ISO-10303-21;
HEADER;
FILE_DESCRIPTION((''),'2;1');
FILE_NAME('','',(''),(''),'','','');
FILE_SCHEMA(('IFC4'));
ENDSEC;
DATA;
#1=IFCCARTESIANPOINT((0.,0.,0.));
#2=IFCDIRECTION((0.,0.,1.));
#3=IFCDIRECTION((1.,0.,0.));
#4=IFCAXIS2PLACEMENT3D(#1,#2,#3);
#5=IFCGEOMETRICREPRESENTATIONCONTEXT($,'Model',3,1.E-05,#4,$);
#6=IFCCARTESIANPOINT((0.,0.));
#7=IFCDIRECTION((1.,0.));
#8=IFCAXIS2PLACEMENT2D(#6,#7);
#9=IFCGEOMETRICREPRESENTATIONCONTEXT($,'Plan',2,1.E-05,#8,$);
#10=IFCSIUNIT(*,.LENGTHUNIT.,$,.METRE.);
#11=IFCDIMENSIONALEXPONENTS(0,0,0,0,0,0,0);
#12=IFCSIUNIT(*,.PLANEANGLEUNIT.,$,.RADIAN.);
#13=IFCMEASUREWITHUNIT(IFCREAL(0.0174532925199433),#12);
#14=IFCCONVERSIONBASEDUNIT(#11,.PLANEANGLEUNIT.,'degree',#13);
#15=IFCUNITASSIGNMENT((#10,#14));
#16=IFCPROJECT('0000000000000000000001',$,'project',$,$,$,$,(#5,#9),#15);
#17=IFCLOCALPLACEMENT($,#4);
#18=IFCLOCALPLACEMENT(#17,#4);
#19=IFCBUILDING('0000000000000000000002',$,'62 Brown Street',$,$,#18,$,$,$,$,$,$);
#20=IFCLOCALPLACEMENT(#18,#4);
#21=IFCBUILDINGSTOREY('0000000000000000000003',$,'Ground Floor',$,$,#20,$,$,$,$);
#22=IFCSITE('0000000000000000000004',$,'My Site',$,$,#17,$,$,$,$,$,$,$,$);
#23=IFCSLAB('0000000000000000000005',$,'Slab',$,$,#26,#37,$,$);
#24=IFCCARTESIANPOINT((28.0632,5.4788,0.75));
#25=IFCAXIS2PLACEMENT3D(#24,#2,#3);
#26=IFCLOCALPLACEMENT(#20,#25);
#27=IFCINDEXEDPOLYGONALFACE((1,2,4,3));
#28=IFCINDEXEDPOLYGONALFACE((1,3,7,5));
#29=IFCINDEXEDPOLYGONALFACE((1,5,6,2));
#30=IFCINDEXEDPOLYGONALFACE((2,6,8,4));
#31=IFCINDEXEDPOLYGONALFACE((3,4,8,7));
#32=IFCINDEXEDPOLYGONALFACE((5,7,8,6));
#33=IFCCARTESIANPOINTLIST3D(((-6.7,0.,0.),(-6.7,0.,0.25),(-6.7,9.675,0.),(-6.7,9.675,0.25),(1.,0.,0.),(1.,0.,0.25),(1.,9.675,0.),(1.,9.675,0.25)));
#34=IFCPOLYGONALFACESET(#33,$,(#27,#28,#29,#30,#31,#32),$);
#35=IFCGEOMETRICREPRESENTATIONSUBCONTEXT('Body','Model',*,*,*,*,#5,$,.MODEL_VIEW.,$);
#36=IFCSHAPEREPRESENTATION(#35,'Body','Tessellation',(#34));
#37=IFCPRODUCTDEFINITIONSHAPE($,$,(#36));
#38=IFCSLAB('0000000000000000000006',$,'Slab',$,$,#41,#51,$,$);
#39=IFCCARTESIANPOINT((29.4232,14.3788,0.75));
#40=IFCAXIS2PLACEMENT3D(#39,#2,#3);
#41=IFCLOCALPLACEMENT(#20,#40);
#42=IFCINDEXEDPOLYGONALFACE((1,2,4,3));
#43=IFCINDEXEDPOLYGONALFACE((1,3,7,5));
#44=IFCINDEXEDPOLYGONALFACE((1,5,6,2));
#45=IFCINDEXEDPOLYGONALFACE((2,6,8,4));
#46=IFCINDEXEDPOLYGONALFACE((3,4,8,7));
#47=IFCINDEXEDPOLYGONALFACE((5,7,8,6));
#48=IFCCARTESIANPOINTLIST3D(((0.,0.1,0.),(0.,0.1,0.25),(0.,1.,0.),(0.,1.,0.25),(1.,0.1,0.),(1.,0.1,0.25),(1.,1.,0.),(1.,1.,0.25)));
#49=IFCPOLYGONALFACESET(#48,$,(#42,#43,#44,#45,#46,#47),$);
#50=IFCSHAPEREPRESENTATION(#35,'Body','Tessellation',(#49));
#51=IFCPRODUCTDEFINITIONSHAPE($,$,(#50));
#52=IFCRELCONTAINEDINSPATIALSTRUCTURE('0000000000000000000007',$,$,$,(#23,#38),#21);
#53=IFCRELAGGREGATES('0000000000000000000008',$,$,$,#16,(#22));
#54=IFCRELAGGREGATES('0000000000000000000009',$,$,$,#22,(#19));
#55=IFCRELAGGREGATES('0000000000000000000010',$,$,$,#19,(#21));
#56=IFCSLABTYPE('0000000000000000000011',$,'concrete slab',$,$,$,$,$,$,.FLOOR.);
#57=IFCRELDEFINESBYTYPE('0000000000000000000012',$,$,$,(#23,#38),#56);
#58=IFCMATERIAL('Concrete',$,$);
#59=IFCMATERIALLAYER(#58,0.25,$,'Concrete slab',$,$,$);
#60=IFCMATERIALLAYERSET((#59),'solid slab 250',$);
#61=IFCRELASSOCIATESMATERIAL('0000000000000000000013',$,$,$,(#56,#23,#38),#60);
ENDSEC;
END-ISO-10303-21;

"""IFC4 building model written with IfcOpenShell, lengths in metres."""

from ifc_helpers import new_model, entity, si_unit, converted_unit, frame, origin_with_axes, origin_2d_with_axis, place, context, subcontext, project, spatial, line, indexed_curve, outline, extrude, material, layer, layer_set, layer_usage, type_object, element, save


model = new_model("IFC4")

# Units and contexts
model_context = context("Model", 3, precision=1e-05, world=origin_with_axes())
plan_context = context("Plan", 2, precision=1e-05, world=origin_2d_with_axis())
body_context_1 = subcontext(model_context, "Body", "Model", "MODEL_VIEW")
ifc_project = project(units=[si_unit("LENGTHUNIT", "METRE"), converted_unit("PLANEANGLEUNIT", "degree", entity("IfcReal", 0.0174532925199433), si_unit("PLANEANGLEUNIT", "RADIAN"), dimensions=[0, 0, 0, 0, 0, 0, 0])], contexts=[model_context, plan_context])

# Site, building, storey
site_placement = place(None, origin_with_axes())
site = spatial("IfcSite", under=ifc_project, at=site_placement, Name="My Site")
building_placement = place(site_placement, origin_with_axes())
building = spatial("IfcBuilding", under=site, at=building_placement, Name="62 Brown Street")
storey_placement = place(building_placement, origin_with_axes())
storey = spatial("IfcBuildingStorey", under=building, at=storey_placement, Name="Ground Floor")

# Shared definitions
ifc_material_1 = material(Name="Concrete")

# Slabs
ifc_layer_1 = layer(ifc_material_1, 0.25, Name="Concrete slab")
ifc_layer_set_1 = layer_set([ifc_layer_1], Name="solid slab 250")
slab_type = type_object("IfcSlabType", Name="concrete slab", PredefinedType="FLOOR", material=ifc_layer_set_1)
ifc_layer_usage_1 = layer_usage(ifc_layer_set_1, "AXIS3", "POSITIVE", 0.0)
slab_1_placement = place(storey_placement, frame((28.0632, 5.4788, 0.75), z_axis=(0.0, 0.0, 1.0), x_axis=(1.0, 0.0, 0.0)))
element("IfcSlab", 1, at=slab_1_placement, inside=storey, type_object=slab_type, material=ifc_layer_usage_1, Name="Slab", context=body_context_1, shape_type="SweptSolid", body=[
    extrude(outline(indexed_curve([(1.0, 9.675), (-6.7, 9.675), (-6.7, 0.0), (1.0, 0.0)], segments=[line(3, 2), line(2, 1), line(1, 4), line(4, 3)], self_intersect=False)), None, (0.0, 0.0, 1.0), 0.25),
])
ifc_layer_usage_2 = layer_usage(ifc_layer_set_1, "AXIS3", "POSITIVE", 0.0)
slab_2_placement = place(storey_placement, frame((29.4232, 14.3788, 0.75), z_axis=(0.0, 0.0, 1.0), x_axis=(1.0, 0.0, 0.0)))
element("IfcSlab", 2, at=slab_2_placement, inside=storey, type_object=slab_type, material=ifc_layer_usage_2, Name="Slab", context=body_context_1, shape_type="SweptSolid", body=[
    extrude(outline(indexed_curve([(1.0, 1.0), (1.0, 0.1), (0.0, 0.1), (0.0, 1.0)], segments=[line(3, 2), line(2, 1), line(1, 4), line(4, 3)], self_intersect=False)), None, (0.0, 0.0, 1.0), 0.25),
])

save(model, "model.ifc")
